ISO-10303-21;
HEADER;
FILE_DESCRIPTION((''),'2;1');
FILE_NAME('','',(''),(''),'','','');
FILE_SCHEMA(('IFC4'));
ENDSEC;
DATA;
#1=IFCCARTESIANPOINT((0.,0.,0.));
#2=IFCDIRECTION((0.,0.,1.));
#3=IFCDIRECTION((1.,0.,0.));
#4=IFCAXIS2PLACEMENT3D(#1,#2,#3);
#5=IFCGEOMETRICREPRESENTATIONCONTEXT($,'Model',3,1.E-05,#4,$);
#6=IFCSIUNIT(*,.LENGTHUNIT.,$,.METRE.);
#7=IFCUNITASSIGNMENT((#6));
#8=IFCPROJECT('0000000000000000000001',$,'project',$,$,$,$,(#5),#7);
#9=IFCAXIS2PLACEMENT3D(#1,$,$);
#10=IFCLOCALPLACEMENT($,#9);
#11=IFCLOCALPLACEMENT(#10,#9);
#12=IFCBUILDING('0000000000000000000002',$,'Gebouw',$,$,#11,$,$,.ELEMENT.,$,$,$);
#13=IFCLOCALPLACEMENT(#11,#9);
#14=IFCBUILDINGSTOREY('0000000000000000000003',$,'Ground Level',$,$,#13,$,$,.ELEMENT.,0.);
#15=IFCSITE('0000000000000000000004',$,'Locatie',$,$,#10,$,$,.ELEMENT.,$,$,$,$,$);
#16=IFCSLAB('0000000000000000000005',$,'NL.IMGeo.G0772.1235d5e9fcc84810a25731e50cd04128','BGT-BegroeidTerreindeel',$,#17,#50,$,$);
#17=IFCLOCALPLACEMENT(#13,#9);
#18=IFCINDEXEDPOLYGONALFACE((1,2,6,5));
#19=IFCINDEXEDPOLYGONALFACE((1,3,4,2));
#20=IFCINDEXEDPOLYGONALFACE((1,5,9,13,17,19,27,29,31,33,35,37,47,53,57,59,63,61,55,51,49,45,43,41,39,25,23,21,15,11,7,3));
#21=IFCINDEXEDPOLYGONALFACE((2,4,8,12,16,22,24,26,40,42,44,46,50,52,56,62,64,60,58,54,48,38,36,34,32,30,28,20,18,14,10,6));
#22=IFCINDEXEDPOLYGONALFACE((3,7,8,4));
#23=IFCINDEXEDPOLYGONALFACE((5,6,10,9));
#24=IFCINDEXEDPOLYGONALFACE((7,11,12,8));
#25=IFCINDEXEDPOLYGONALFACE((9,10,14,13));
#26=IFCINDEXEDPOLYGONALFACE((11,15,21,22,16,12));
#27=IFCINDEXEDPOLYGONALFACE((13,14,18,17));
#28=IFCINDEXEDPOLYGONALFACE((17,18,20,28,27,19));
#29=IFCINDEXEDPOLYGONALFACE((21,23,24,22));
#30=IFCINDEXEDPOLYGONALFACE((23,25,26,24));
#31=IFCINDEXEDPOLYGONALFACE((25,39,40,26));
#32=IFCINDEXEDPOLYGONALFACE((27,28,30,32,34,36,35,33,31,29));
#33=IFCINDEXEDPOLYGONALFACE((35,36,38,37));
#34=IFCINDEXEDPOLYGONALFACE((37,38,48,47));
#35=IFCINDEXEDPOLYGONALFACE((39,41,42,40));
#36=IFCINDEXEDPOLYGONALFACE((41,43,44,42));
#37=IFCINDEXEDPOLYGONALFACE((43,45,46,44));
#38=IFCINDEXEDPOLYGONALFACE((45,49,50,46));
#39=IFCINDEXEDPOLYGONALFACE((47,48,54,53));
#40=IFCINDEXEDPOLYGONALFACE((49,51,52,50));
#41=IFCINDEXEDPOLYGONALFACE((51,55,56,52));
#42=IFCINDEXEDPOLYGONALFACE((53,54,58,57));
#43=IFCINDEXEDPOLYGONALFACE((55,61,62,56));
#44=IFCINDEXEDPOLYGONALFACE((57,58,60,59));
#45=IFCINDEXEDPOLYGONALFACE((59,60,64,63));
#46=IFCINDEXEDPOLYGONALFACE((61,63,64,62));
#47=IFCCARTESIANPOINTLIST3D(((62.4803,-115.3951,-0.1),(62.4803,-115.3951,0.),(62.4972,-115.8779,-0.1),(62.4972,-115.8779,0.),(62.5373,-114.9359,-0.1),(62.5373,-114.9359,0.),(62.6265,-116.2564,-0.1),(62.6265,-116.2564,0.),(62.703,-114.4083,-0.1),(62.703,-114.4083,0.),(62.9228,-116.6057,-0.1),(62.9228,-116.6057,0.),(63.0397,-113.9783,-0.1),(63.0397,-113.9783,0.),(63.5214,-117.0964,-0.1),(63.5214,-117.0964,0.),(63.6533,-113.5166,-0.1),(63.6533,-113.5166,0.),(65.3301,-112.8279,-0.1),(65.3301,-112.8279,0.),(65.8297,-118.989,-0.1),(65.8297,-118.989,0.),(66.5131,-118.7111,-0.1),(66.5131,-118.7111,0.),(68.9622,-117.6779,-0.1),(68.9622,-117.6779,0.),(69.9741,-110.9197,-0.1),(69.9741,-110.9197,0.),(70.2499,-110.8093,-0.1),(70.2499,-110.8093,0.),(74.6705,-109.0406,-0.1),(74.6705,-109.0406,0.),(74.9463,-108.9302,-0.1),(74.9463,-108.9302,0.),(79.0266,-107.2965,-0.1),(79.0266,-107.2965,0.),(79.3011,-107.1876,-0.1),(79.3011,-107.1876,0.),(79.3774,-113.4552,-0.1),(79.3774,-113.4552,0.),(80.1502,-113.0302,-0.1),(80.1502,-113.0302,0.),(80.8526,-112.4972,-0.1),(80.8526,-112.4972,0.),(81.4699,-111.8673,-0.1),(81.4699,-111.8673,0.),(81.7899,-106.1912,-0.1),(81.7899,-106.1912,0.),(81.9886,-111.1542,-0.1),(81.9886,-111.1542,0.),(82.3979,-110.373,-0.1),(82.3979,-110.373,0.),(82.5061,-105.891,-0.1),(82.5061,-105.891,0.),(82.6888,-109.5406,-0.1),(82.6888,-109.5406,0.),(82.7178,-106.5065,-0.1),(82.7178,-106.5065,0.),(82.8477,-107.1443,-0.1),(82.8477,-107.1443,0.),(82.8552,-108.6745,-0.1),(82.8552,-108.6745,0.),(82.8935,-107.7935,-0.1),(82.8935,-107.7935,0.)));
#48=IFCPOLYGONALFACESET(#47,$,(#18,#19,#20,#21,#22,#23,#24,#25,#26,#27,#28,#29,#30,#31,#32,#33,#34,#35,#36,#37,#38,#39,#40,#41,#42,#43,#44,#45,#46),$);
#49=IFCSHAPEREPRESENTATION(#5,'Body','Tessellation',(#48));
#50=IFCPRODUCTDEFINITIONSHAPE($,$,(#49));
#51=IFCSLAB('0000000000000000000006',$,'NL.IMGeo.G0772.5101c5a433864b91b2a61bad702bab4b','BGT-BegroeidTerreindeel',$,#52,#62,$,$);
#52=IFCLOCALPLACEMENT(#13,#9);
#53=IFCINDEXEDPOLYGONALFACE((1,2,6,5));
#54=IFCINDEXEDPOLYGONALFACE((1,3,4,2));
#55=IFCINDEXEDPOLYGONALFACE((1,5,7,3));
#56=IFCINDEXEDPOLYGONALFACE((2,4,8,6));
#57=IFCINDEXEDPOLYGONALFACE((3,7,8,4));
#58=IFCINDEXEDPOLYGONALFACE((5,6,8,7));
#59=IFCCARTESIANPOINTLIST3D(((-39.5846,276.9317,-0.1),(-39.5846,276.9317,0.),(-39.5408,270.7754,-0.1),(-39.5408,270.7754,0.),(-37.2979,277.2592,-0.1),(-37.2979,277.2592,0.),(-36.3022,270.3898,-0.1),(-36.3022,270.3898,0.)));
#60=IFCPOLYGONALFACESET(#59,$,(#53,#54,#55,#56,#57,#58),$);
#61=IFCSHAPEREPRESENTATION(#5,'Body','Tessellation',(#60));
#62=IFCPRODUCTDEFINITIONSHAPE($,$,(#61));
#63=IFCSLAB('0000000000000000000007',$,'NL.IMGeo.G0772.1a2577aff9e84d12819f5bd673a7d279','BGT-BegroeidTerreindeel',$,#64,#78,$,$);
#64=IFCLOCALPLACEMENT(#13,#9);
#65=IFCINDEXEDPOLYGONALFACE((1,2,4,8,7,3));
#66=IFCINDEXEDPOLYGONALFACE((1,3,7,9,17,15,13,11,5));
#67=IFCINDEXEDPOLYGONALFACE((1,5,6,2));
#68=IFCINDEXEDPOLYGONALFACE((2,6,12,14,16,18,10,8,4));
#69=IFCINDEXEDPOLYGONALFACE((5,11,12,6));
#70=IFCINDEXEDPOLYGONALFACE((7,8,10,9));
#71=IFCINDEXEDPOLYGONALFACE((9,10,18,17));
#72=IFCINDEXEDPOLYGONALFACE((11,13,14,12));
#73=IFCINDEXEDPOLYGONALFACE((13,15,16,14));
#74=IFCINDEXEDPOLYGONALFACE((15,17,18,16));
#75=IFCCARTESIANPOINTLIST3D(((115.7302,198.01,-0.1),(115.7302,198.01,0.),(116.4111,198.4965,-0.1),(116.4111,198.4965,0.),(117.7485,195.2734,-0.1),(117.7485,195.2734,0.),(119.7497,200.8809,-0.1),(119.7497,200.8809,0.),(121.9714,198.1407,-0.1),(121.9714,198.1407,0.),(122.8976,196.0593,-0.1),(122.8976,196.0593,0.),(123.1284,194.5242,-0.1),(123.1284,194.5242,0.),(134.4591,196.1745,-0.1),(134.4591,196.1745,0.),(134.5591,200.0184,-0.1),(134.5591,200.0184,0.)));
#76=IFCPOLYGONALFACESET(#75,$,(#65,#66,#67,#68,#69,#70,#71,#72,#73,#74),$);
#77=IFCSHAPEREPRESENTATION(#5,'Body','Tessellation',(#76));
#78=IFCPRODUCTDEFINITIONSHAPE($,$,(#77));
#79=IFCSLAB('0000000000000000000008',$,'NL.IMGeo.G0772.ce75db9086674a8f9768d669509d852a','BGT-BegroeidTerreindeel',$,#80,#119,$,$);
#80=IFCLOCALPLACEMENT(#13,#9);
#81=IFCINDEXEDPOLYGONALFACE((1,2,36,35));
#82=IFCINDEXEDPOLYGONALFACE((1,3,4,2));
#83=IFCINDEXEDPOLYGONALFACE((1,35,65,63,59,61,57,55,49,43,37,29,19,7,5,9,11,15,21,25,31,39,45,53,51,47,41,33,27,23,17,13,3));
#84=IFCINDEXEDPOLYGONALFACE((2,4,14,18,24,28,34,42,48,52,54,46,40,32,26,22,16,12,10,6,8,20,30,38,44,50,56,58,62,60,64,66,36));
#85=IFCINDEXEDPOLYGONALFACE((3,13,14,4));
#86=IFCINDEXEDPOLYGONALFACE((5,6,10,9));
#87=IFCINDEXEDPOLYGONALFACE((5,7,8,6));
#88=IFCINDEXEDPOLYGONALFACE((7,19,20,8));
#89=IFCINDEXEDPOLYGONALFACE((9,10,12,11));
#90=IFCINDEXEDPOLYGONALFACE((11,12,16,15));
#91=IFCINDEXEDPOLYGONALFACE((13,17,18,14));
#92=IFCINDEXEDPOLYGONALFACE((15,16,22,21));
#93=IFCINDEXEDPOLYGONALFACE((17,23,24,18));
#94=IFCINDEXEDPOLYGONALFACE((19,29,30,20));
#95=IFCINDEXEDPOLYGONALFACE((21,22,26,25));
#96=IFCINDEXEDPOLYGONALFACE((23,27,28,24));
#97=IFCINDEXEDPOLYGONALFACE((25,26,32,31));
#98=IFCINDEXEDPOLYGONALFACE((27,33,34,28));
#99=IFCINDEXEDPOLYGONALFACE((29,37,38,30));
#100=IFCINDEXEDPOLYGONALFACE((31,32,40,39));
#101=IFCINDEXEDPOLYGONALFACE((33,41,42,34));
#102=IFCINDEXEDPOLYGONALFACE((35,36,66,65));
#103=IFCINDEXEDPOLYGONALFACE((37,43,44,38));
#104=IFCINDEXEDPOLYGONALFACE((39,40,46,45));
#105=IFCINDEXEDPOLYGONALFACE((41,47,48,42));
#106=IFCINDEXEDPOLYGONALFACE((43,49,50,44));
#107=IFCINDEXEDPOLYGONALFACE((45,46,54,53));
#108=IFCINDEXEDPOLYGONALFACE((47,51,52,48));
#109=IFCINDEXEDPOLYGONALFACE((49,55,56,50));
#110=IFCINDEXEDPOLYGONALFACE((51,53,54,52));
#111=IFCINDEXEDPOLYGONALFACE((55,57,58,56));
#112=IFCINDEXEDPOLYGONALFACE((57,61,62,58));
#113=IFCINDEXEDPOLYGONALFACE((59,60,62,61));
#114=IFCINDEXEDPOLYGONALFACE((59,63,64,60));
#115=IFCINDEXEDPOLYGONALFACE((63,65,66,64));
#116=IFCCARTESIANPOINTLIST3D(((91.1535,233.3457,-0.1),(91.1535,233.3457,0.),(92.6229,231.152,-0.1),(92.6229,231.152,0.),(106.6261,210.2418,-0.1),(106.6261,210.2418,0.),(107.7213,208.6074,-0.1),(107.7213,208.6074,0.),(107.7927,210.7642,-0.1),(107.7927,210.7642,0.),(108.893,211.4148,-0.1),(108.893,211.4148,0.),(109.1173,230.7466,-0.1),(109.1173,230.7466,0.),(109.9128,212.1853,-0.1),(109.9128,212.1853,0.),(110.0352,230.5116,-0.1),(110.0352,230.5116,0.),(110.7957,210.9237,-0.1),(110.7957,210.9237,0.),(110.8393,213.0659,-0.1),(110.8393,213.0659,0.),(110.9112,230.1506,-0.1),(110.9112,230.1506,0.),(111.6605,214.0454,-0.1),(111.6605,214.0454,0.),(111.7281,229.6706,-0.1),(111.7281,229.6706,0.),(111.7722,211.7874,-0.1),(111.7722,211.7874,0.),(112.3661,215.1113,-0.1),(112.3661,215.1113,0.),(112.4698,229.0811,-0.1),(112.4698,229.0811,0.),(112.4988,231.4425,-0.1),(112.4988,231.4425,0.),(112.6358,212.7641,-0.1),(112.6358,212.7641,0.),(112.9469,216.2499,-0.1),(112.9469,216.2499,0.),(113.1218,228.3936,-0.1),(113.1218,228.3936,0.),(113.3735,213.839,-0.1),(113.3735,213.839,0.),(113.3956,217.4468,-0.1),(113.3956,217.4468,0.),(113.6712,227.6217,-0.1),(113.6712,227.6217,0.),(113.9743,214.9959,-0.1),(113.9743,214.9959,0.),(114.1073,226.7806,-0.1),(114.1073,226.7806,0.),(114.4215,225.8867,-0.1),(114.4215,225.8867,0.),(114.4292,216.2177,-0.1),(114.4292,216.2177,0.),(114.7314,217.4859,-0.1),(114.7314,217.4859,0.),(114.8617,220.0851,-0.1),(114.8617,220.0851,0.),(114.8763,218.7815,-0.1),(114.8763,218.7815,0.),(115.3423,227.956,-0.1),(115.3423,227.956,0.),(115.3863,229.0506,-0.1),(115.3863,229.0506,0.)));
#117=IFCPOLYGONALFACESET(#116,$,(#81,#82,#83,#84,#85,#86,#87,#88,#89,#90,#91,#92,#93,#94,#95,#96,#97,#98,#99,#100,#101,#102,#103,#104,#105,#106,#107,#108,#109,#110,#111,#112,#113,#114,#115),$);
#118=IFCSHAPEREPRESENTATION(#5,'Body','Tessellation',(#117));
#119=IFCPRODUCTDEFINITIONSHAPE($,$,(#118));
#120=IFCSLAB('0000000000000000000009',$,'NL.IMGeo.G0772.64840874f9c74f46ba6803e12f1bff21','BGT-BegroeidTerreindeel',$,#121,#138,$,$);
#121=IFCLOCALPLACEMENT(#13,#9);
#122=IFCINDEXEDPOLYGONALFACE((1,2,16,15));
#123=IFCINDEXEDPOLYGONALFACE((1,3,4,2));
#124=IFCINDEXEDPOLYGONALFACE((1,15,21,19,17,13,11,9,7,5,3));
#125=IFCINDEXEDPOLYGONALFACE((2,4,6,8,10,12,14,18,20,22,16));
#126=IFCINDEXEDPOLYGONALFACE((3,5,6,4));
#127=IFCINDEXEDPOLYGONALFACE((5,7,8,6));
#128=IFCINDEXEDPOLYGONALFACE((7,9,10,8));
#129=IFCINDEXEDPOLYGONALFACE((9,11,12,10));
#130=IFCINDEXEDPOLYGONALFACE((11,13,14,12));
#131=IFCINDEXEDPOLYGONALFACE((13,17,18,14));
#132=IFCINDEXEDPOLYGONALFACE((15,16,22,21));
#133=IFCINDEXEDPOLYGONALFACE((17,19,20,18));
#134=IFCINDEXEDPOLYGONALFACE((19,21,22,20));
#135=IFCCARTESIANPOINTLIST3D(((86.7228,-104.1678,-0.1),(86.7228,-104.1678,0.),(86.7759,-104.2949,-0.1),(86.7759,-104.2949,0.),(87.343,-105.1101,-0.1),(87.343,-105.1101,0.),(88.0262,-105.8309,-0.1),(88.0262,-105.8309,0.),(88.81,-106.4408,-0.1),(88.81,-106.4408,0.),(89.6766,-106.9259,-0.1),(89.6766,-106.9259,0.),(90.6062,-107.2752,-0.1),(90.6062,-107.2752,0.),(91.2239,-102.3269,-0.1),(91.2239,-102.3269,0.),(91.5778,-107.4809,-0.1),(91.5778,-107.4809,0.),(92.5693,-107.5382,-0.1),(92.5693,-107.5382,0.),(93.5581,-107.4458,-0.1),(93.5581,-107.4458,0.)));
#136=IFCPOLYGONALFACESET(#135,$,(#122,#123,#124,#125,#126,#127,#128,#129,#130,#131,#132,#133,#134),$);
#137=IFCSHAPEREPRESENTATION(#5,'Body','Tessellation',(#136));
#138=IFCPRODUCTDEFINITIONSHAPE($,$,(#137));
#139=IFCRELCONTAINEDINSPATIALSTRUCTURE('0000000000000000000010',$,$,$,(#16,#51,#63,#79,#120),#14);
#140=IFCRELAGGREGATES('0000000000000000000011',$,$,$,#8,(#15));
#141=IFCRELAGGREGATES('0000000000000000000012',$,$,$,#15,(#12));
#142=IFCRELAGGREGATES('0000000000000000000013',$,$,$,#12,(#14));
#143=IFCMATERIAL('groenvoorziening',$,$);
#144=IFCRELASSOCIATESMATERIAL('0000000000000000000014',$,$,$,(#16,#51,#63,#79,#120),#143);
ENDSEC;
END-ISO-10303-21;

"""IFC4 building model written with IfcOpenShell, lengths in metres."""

from ifc_helpers import new_model, si_unit, frame, origin, origin_with_axes, place, context, project, spatial, polyline, outline, extrude, material, element, save


model = new_model("IFC4")

# Units and contexts
model_context = context("Model", 3, precision=1e-05, world=origin_with_axes())
ifc_project = project(units=[si_unit("LENGTHUNIT", "METRE")], contexts=[model_context])

# Site, building, storey
site_placement = place(None, origin())
site = spatial("IfcSite", under=ifc_project, at=site_placement, Name="Locatie", CompositionType="ELEMENT")
building_placement = place(site_placement, origin())
building = spatial("IfcBuilding", under=site, at=building_placement, Name="Gebouw", CompositionType="ELEMENT")
storey_placement = place(building_placement, origin())
storey = spatial("IfcBuildingStorey", under=building, at=storey_placement, Name="Ground Level", CompositionType="ELEMENT", Elevation=0.0)

# Slabs
ifc_material = material(Name="groenvoorziening")
slab_1_placement = place(storey_placement, origin())
element("IfcSlab", 1, at=slab_1_placement, inside=storey, material=ifc_material, Name="NL.IMGeo.G0772.1235d5e9fcc84810a25731e50cd04128", Description="BGT-BegroeidTerreindeel", context=model_context, shape_type="SweptSolid", body=[
    extrude(outline(polyline([(74.9463, -108.9302), (79.0266, -107.2965), (79.3011, -107.1876), (81.7899, -106.1912), (82.5061, -105.891), (82.7178, -106.5065), (82.8477, -107.1443), (82.8935, -107.7935), (82.8552, -108.6745), (82.6888, -109.5406), (82.3979, -110.373), (81.9886, -111.1542), (81.4699, -111.8673), (80.8526, -112.4972), (80.1502, -113.0302), (79.3774, -113.4552), (68.9622, -117.6779), (66.5131, -118.7111), (65.8297, -118.989), (63.5214, -117.0964), (62.9228, -116.6057), (62.6265, -116.2564), (62.4972, -115.8779), (62.4803, -115.3951), (62.5373, -114.9359), (62.703, -114.4083), (63.0397, -113.9783), (63.6533, -113.5166), (65.3301, -112.8279), (69.9741, -110.9197), (70.2499, -110.8093), (74.6705, -109.0406), (74.9463, -108.9302)])), frame((0.0, 0.0, -0.1), z_axis=(0.0, 0.0, 1.0), x_axis=(1.0, 0.0, 0.0)), (0.0, 0.0, 1.0), 0.1),
])
slab_2_placement = place(storey_placement, origin())
element("IfcSlab", 2, at=slab_2_placement, inside=storey, material=ifc_material, Name="NL.IMGeo.G0772.5101c5a433864b91b2a61bad702bab4b", Description="BGT-BegroeidTerreindeel", context=model_context, shape_type="SweptSolid", body=[
    extrude(outline(polyline([(-37.2979, 277.2592), (-36.3022, 270.3898), (-39.5408, 270.7754), (-39.5846, 276.9317), (-37.2979, 277.2592)])), frame((0.0, 0.0, -0.1), z_axis=(0.0, 0.0, 1.0), x_axis=(1.0, 0.0, 0.0)), (0.0, 0.0, 1.0), 0.1),
])
slab_3_placement = place(storey_placement, origin())
element("IfcSlab", 3, at=slab_3_placement, inside=storey, material=ifc_material, Name="NL.IMGeo.G0772.1a2577aff9e84d12819f5bd673a7d279", Description="BGT-BegroeidTerreindeel", context=model_context, shape_type="SweptSolid", body=[
    extrude(outline(polyline([(134.5591, 200.0184), (134.4591, 196.1745), (123.1284, 194.5242), (122.8976, 196.0593), (117.7485, 195.2734), (115.7302, 198.01), (116.4111, 198.4965), (119.7497, 200.8809), (121.9714, 198.1407), (134.5591, 200.0184)])), frame((0.0, 0.0, -0.1), z_axis=(0.0, 0.0, 1.0), x_axis=(1.0, 0.0, 0.0)), (0.0, 0.0, 1.0), 0.1),
])
slab_4_placement = place(storey_placement, origin())
element("IfcSlab", 4, at=slab_4_placement, inside=storey, material=ifc_material, Name="NL.IMGeo.G0772.ce75db9086674a8f9768d669509d852a", Description="BGT-BegroeidTerreindeel", context=model_context, shape_type="SweptSolid", body=[
    extrude(outline(polyline([(115.3423, 227.956), (114.8617, 220.0851), (114.8763, 218.7815), (114.7314, 217.4859), (114.4292, 216.2177), (113.9743, 214.9959), (113.3735, 213.839), (112.6358, 212.7641), (111.7722, 211.7874), (110.7957, 210.9237), (107.7213, 208.6074), (106.6261, 210.2418), (107.7927, 210.7642), (108.893, 211.4148), (109.9128, 212.1853), (110.8393, 213.0659), (111.6605, 214.0454), (112.3661, 215.1113), (112.9469, 216.2499), (113.3956, 217.4468), (114.4215, 225.8867), (114.1073, 226.7806), (113.6712, 227.6217), (113.1218, 228.3936), (112.4698, 229.0811), (111.7281, 229.6706), (110.9112, 230.1506), (110.0352, 230.5116), (109.1173, 230.7466), (92.6229, 231.152), (91.1535, 233.3457), (112.4988, 231.4425), (115.3863, 229.0506), (115.3423, 227.956)])), frame((0.0, 0.0, -0.1), z_axis=(0.0, 0.0, 1.0), x_axis=(1.0, 0.0, 0.0)), (0.0, 0.0, 1.0), 0.1),
])
slab_5_placement = place(storey_placement, origin())
element("IfcSlab", 5, at=slab_5_placement, inside=storey, material=ifc_material, Name="NL.IMGeo.G0772.64840874f9c74f46ba6803e12f1bff21", Description="BGT-BegroeidTerreindeel", context=model_context, shape_type="SweptSolid", body=[
    extrude(outline(polyline([(93.5581, -107.4458), (92.5693, -107.5382), (91.5778, -107.4809), (90.6062, -107.2752), (89.6766, -106.9259), (88.81, -106.4408), (88.0262, -105.8309), (87.343, -105.1101), (86.7759, -104.2949), (86.7228, -104.1678), (91.2239, -102.3269), (93.5581, -107.4458)])), frame((0.0, 0.0, -0.1), z_axis=(0.0, 0.0, 1.0), x_axis=(1.0, 0.0, 0.0)), (0.0, 0.0, 1.0), 0.1),
])

save(model, "model.ifc")
